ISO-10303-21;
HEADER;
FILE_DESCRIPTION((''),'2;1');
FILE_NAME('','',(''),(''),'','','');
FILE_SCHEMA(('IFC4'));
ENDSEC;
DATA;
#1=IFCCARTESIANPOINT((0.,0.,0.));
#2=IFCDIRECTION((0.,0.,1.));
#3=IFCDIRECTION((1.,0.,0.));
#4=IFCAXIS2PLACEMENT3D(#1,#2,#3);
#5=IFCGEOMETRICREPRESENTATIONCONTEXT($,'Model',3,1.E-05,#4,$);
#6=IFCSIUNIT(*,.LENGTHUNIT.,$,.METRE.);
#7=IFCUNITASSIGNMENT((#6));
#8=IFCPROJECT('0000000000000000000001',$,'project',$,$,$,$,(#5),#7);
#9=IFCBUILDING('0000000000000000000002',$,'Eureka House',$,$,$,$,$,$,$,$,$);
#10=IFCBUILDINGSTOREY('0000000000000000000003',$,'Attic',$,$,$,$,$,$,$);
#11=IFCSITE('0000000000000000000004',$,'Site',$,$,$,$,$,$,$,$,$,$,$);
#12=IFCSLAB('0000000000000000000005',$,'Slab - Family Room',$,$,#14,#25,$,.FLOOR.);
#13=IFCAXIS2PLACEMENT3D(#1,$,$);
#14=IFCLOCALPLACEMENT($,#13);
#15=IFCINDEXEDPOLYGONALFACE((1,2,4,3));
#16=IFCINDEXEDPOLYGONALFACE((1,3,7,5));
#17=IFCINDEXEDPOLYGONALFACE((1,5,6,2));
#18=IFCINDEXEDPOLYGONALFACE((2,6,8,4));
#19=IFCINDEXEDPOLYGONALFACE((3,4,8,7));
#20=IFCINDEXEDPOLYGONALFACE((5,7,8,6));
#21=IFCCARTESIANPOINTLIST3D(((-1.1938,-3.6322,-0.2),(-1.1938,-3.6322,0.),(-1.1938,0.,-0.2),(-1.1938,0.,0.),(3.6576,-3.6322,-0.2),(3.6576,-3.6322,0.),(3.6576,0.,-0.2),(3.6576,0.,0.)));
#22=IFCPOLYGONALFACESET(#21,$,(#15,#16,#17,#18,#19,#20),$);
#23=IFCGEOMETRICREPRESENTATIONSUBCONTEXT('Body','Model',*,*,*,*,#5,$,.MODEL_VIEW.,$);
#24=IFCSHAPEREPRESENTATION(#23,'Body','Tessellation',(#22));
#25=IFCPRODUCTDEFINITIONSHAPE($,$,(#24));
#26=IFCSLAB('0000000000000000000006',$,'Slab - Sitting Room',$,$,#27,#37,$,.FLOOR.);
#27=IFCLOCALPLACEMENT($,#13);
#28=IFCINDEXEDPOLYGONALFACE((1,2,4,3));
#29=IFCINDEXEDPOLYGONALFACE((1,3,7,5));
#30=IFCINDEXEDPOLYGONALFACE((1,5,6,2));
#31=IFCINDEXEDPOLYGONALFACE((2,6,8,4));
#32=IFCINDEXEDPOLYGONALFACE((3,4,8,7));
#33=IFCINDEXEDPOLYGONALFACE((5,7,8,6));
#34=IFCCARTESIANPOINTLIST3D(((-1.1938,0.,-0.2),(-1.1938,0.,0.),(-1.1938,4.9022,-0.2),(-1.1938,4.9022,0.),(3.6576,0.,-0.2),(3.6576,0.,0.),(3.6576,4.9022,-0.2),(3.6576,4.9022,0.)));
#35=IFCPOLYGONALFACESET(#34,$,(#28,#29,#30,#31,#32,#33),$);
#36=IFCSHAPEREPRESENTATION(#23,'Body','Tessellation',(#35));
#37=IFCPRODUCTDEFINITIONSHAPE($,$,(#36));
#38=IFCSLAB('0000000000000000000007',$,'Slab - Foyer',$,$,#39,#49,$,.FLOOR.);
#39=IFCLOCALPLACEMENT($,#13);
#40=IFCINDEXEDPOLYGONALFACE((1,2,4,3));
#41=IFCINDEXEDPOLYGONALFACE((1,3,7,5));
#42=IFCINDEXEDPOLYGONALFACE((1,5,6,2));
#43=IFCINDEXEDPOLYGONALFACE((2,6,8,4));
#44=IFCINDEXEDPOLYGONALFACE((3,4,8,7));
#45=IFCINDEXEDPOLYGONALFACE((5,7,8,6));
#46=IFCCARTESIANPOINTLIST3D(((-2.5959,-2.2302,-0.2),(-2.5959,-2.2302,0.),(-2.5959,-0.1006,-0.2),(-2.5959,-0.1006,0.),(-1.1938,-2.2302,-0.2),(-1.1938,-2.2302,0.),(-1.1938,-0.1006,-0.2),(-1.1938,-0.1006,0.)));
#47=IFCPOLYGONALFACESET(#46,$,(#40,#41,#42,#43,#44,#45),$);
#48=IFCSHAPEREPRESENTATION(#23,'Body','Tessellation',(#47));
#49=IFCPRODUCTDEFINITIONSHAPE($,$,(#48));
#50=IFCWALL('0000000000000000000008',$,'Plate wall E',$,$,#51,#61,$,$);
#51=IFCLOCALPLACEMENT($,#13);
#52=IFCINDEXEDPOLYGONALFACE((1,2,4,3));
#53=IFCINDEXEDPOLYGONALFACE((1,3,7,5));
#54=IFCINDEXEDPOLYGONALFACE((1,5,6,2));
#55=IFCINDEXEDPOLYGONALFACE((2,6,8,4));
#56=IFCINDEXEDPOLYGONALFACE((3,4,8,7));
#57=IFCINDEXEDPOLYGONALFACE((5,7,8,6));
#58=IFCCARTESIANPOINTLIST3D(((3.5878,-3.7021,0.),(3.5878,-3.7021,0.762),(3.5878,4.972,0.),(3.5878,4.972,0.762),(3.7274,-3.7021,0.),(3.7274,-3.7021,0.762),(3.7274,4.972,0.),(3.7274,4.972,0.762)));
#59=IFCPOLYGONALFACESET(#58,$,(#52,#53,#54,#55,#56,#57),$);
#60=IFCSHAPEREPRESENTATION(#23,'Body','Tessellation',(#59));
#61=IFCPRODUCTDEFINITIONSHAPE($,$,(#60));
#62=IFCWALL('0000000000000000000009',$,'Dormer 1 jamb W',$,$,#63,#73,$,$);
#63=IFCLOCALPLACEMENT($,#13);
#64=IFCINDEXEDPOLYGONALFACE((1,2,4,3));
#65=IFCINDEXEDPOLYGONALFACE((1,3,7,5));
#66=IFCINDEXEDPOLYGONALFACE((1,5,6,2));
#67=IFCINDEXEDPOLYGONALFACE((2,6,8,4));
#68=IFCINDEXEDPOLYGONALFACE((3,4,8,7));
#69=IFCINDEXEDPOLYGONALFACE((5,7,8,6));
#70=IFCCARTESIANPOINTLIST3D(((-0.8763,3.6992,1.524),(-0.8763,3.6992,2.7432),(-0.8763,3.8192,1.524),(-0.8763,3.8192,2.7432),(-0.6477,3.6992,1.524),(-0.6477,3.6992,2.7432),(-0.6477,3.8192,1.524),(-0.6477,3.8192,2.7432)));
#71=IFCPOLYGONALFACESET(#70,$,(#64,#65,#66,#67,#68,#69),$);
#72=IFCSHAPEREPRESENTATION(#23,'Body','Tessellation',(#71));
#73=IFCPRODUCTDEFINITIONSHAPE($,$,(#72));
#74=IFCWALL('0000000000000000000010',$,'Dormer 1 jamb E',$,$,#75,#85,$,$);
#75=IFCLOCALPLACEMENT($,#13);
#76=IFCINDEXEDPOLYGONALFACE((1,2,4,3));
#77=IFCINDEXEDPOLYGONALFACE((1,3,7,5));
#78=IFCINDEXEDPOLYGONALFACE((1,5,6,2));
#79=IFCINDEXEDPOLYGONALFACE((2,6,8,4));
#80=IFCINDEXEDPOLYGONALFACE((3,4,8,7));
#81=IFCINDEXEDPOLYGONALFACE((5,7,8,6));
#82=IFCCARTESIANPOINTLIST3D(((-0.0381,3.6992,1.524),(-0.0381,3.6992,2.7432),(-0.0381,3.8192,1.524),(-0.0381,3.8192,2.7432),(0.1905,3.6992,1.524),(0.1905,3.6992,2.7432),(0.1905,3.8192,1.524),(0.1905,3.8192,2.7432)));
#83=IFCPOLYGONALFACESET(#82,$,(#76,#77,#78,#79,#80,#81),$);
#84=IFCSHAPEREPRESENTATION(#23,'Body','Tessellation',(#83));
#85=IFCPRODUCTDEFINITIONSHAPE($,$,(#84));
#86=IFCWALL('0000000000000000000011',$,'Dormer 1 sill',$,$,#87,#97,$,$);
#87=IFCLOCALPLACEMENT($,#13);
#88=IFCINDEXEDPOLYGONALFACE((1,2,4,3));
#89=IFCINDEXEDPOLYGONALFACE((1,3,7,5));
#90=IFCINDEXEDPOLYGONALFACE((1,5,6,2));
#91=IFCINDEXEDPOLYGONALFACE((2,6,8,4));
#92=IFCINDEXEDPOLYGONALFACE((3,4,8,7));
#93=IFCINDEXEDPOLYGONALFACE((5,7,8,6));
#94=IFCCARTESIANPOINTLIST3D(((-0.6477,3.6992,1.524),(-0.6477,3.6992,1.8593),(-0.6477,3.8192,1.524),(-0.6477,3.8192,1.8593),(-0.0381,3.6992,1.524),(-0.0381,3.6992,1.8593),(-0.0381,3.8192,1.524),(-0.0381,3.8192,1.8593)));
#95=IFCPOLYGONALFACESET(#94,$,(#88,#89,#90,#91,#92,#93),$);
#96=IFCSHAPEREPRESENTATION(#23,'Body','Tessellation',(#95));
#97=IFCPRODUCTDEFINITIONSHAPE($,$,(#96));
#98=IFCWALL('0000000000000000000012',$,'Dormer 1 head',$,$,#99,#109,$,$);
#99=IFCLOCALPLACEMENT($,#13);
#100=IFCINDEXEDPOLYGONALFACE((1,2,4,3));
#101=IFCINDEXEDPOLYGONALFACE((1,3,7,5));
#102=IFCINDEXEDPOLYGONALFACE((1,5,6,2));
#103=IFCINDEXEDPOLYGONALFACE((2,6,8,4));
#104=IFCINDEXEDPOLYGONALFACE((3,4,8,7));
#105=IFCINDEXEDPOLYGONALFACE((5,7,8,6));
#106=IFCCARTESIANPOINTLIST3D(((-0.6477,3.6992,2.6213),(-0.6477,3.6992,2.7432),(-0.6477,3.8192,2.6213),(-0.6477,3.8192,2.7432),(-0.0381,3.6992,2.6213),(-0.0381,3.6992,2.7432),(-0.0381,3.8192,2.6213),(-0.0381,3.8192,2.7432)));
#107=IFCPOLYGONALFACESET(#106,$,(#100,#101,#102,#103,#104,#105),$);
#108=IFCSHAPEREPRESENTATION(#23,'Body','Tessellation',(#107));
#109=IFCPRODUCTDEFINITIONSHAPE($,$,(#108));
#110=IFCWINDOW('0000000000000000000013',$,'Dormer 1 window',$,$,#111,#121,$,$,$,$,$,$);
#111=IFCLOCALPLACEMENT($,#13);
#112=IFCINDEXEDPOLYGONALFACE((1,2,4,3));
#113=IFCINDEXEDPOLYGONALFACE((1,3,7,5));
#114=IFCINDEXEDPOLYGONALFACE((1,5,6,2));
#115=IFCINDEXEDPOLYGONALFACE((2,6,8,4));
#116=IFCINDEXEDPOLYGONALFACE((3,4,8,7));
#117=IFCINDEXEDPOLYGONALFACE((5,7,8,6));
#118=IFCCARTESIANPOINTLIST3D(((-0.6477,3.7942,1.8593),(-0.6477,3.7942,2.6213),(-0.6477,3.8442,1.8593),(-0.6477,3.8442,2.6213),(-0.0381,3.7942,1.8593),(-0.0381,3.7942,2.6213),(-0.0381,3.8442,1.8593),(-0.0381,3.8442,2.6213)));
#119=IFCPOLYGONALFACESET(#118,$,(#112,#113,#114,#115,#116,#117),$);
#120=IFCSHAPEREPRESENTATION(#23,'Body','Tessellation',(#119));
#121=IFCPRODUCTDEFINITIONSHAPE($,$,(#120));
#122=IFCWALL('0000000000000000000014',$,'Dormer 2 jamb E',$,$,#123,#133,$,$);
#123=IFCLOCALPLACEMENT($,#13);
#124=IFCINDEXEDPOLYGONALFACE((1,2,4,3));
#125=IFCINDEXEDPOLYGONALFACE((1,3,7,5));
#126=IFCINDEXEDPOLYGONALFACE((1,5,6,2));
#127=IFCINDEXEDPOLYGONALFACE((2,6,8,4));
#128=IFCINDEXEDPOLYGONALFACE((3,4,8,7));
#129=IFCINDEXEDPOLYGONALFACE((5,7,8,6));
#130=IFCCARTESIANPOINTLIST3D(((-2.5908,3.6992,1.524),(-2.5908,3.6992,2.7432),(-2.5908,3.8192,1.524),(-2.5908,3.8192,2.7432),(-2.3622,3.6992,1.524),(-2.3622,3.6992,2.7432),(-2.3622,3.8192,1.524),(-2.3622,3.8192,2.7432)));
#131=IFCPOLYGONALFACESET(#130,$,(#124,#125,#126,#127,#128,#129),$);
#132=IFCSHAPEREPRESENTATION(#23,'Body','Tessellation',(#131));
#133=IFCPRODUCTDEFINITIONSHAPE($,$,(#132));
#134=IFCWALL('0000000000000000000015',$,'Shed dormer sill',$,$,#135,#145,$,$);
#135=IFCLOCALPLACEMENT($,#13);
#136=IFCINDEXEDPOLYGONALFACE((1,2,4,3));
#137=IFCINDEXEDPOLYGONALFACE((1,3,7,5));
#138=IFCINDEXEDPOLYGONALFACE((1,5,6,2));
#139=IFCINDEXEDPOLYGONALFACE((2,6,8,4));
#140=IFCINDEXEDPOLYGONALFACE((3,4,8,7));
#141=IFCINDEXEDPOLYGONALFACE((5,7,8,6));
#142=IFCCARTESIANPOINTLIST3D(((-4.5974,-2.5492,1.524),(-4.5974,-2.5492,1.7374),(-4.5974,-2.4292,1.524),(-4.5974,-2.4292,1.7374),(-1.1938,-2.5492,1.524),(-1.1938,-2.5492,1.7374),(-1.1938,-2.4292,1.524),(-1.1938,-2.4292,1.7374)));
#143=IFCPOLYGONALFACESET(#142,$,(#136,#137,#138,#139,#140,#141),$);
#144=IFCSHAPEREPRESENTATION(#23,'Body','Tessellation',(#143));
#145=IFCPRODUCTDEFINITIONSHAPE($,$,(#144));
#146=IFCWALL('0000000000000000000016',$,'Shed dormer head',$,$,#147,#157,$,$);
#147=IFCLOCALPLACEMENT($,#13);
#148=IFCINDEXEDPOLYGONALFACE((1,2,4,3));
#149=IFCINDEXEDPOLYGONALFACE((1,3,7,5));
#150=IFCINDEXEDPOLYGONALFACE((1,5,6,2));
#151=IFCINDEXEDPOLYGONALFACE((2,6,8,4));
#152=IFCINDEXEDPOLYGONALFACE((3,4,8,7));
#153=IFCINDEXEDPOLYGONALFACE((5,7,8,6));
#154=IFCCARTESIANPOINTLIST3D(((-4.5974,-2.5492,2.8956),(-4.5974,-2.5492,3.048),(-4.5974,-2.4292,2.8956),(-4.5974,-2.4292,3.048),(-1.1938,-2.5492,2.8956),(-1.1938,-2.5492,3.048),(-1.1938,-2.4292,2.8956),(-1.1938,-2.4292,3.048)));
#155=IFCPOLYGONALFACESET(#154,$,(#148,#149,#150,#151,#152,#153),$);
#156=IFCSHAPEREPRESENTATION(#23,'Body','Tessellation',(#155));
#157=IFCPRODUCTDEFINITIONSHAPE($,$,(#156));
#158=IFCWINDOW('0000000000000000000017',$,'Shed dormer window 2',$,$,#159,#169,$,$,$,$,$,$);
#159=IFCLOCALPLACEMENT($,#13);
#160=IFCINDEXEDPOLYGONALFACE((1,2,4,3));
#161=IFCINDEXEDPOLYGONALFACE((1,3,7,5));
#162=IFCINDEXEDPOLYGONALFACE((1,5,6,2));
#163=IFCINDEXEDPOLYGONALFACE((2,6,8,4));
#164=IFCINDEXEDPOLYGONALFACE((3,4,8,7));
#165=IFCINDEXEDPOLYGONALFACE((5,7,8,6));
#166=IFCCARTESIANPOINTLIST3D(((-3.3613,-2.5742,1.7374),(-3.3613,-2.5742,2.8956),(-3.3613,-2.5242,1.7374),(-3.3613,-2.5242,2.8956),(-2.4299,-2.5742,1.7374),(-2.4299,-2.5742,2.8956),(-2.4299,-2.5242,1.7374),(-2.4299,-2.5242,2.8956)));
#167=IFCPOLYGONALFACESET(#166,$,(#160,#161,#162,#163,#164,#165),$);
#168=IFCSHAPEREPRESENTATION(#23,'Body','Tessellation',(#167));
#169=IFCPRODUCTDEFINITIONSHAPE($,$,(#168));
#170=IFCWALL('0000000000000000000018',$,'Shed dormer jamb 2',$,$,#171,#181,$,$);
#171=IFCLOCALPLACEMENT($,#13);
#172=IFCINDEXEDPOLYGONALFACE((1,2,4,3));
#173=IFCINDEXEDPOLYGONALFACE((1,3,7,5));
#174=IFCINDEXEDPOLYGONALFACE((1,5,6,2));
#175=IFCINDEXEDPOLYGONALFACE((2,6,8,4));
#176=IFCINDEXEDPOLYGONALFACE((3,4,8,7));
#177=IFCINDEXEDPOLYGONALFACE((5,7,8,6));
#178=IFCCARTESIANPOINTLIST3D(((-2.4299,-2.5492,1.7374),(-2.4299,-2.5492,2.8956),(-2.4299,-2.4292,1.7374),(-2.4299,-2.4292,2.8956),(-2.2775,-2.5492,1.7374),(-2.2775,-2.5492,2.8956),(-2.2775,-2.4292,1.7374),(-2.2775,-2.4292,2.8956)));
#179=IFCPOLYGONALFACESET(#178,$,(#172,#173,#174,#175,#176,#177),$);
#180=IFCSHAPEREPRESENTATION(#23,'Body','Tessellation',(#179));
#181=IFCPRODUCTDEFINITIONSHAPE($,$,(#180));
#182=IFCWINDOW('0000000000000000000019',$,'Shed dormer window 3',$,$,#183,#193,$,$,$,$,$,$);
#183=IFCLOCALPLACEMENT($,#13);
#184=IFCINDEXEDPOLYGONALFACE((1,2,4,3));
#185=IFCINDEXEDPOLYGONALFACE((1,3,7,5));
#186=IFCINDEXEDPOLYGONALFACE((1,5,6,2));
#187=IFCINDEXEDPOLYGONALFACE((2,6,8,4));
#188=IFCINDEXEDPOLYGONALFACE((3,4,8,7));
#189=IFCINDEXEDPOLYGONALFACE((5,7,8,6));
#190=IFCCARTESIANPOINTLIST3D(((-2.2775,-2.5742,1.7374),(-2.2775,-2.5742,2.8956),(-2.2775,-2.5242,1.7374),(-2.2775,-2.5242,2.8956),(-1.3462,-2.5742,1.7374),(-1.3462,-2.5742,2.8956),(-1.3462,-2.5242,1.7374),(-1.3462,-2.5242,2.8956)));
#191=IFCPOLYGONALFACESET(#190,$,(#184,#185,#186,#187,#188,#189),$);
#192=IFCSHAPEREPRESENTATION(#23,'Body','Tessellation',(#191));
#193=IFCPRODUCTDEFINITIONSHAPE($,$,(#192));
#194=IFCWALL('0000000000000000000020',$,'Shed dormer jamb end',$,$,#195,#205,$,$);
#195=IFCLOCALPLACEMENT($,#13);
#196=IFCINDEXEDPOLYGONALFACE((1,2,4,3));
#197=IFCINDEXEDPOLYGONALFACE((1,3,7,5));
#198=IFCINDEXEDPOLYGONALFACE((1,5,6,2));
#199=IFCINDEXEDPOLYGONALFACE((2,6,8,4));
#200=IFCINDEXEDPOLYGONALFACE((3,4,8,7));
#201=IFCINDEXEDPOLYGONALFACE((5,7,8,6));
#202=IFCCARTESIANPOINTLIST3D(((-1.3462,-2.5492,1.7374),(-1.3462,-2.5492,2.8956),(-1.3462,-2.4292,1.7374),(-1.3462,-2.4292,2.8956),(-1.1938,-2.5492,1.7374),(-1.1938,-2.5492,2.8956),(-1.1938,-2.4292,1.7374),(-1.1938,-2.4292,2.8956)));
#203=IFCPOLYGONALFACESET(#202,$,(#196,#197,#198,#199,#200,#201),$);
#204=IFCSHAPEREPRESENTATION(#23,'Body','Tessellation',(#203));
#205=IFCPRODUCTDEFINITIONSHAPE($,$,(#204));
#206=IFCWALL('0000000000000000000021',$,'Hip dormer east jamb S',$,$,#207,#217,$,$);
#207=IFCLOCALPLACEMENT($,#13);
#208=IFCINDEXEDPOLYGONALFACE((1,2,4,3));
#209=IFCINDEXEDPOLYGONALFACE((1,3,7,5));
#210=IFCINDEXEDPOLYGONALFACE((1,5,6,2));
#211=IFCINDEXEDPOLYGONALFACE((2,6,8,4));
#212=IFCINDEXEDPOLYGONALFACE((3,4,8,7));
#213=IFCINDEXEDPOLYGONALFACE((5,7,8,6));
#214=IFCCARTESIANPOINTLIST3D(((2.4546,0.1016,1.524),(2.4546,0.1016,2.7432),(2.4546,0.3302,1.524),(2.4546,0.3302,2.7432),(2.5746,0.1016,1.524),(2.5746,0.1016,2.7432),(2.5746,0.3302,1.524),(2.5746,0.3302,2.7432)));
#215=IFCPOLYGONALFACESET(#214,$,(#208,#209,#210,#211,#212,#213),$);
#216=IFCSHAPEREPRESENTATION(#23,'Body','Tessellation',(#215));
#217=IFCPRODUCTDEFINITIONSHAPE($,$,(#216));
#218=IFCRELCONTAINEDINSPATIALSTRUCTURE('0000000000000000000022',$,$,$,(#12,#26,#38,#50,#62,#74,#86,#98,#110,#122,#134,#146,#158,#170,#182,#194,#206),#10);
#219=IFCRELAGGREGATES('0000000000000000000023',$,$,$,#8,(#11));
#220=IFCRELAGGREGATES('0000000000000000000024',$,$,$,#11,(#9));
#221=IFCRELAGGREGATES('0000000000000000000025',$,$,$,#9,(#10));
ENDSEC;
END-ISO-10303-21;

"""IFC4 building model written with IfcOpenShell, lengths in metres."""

from ifc_helpers import new_model, si_unit, frame, origin, origin_with_axes, origin_2d, place, context, subcontext, project, spatial, rectangle, extrude, element, save


model = new_model("IFC4")

# Units and contexts
model_context = context("Model", 3, precision=1e-05, world=origin_with_axes())
body_context = subcontext(model_context, "Body", "Model", "MODEL_VIEW")
ifc_project = project(units=[si_unit("LENGTHUNIT", "METRE")], contexts=[model_context])

# Site, building, storey
site = spatial("IfcSite", under=ifc_project, Name="Site")
building = spatial("IfcBuilding", under=site, Name="Eureka House")
storey = spatial("IfcBuildingStorey", under=building, Name="Attic")

# Slabs
slab_1_placement = place(None, frame((1.2319, -1.8161, -0.2), z_axis=(0.0, 0.0, 1.0), x_axis=(1.0, 0.0, 0.0)))
element("IfcSlab", 1, at=slab_1_placement, inside=storey, Name="Slab - Family Room", PredefinedType="FLOOR", context=body_context, shape_type="SweptSolid", body=[
    extrude(rectangle(XDim=4.8514, YDim=3.6322, at=origin_2d()), origin(), (0.0, 0.0, 1.0), 0.2),
])
slab_2_placement = place(None, frame((1.2319, 2.4511, -0.2), z_axis=(0.0, 0.0, 1.0), x_axis=(1.0, 0.0, 0.0)))
element("IfcSlab", 2, at=slab_2_placement, inside=storey, Name="Slab - Sitting Room", PredefinedType="FLOOR", context=body_context, shape_type="SweptSolid", body=[
    extrude(rectangle(XDim=4.8514, YDim=4.9022, at=origin_2d()), origin(), (0.0, 0.0, 1.0), 0.2),
])
slab_3_placement = place(None, frame((-1.8949, -1.1654, -0.2), z_axis=(0.0, 0.0, 1.0), x_axis=(1.0, 0.0, 0.0)))
element("IfcSlab", 3, at=slab_3_placement, inside=storey, Name="Slab - Foyer", PredefinedType="FLOOR", context=body_context, shape_type="SweptSolid", body=[
    extrude(rectangle(XDim=1.4021, YDim=2.1296, at=origin_2d()), origin(), (0.0, 0.0, 1.0), 0.2),
])

# Walls
wall_1_placement = place(None, frame((3.6576, 0.635, 0.0), z_axis=(0.0, 0.0, 1.0), x_axis=(1.0, 0.0, 0.0)))
element("IfcWall", 4, at=wall_1_placement, inside=storey, Name="Plate wall E", context=body_context, shape_type="SweptSolid", body=[
    extrude(rectangle(XDim=0.1397, YDim=8.6741, at=origin_2d()), origin(), (0.0, 0.0, 1.0), 0.762),
])
wall_2_placement = place(None, frame((-0.762, 3.7592, 1.524), z_axis=(0.0, 0.0, 1.0), x_axis=(1.0, 0.0, 0.0)))
element("IfcWall", 5, at=wall_2_placement, inside=storey, Name="Dormer 1 jamb W", context=body_context, shape_type="SweptSolid", body=[
    extrude(rectangle(XDim=0.2286, YDim=0.12, at=origin_2d()), origin(), (0.0, 0.0, 1.0), 1.2192),
])
wall_3_placement = place(None, frame((0.0762, 3.7592, 1.524), z_axis=(0.0, 0.0, 1.0), x_axis=(1.0, 0.0, 0.0)))
element("IfcWall", 6, at=wall_3_placement, inside=storey, Name="Dormer 1 jamb E", context=body_context, shape_type="SweptSolid", body=[
    extrude(rectangle(XDim=0.2286, YDim=0.12, at=origin_2d()), origin(), (0.0, 0.0, 1.0), 1.2192),
])
wall_4_placement = place(None, frame((-0.3429, 3.7592, 1.524), z_axis=(0.0, 0.0, 1.0), x_axis=(1.0, 0.0, 0.0)))
element("IfcWall", 7, at=wall_4_placement, inside=storey, Name="Dormer 1 sill", context=body_context, shape_type="SweptSolid", body=[
    extrude(rectangle(XDim=0.6096, YDim=0.12, at=origin_2d()), origin(), (0.0, 0.0, 1.0), 0.3353),
])
wall_5_placement = place(None, frame((-0.3429, 3.7592, 2.6213), z_axis=(0.0, 0.0, 1.0), x_axis=(1.0, 0.0, 0.0)))
element("IfcWall", 8, at=wall_5_placement, inside=storey, Name="Dormer 1 head", context=body_context, shape_type="SweptSolid", body=[
    extrude(rectangle(XDim=0.6096, YDim=0.12, at=origin_2d()), origin(), (0.0, 0.0, 1.0), 0.1219),
])

# Window
window_1_placement = place(None, frame((-0.3429, 3.8192, 1.8593), z_axis=(0.0, 0.0, 1.0), x_axis=(1.0, 0.0, 0.0)))
element("IfcWindow", 9, at=window_1_placement, inside=storey, Name="Dormer 1 window", context=body_context, shape_type="SweptSolid", body=[
    extrude(rectangle(XDim=0.6096, YDim=0.05, at=origin_2d()), origin(), (0.0, 0.0, 1.0), 0.762),
])

# Walls
wall_6_placement = place(None, frame((-2.4765, 3.7592, 1.524), z_axis=(0.0, 0.0, 1.0), x_axis=(1.0, 0.0, 0.0)))
element("IfcWall", 10, at=wall_6_placement, inside=storey, Name="Dormer 2 jamb E", context=body_context, shape_type="SweptSolid", body=[
    extrude(rectangle(XDim=0.2286, YDim=0.12, at=origin_2d()), origin(), (0.0, 0.0, 1.0), 1.2192),
])
wall_7_placement = place(None, frame((-2.8956, -2.4892, 1.524), z_axis=(0.0, 0.0, 1.0), x_axis=(1.0, 0.0, 0.0)))
element("IfcWall", 11, at=wall_7_placement, inside=storey, Name="Shed dormer sill", context=body_context, shape_type="SweptSolid", body=[
    extrude(rectangle(XDim=3.4036, YDim=0.12, at=origin_2d()), origin(), (0.0, 0.0, 1.0), 0.2134),
])
wall_8_placement = place(None, frame((-2.8956, -2.4892, 2.8956), z_axis=(0.0, 0.0, 1.0), x_axis=(1.0, 0.0, 0.0)))
element("IfcWall", 12, at=wall_8_placement, inside=storey, Name="Shed dormer head", context=body_context, shape_type="SweptSolid", body=[
    extrude(rectangle(XDim=3.4036, YDim=0.12, at=origin_2d()), origin(), (0.0, 0.0, 1.0), 0.1524),
])

# Window
window_2_placement = place(None, frame((-2.8956, -2.5492, 1.7374), z_axis=(0.0, 0.0, 1.0), x_axis=(1.0, 0.0, 0.0)))
element("IfcWindow", 13, at=window_2_placement, inside=storey, Name="Shed dormer window 2", context=body_context, shape_type="SweptSolid", body=[
    extrude(rectangle(XDim=0.9313, YDim=0.05, at=origin_2d()), origin(), (0.0, 0.0, 1.0), 1.1582),
])

# Wall
wall_9_placement = place(None, frame((-2.3537, -2.4892, 1.7374), z_axis=(0.0, 0.0, 1.0), x_axis=(1.0, 0.0, 0.0)))
element("IfcWall", 14, at=wall_9_placement, inside=storey, Name="Shed dormer jamb 2", context=body_context, shape_type="SweptSolid", body=[
    extrude(rectangle(XDim=0.1524, YDim=0.12, at=origin_2d()), origin(), (0.0, 0.0, 1.0), 1.1582),
])

# Window
window_3_placement = place(None, frame((-1.8119, -2.5492, 1.7374), z_axis=(0.0, 0.0, 1.0), x_axis=(1.0, 0.0, 0.0)))
element("IfcWindow", 15, at=window_3_placement, inside=storey, Name="Shed dormer window 3", context=body_context, shape_type="SweptSolid", body=[
    extrude(rectangle(XDim=0.9313, YDim=0.05, at=origin_2d()), origin(), (0.0, 0.0, 1.0), 1.1582),
])

# Walls
wall_10_placement = place(None, frame((-1.27, -2.4892, 1.7374), z_axis=(0.0, 0.0, 1.0), x_axis=(1.0, 0.0, 0.0)))
element("IfcWall", 16, at=wall_10_placement, inside=storey, Name="Shed dormer jamb end", context=body_context, shape_type="SweptSolid", body=[
    extrude(rectangle(XDim=0.1524, YDim=0.12, at=origin_2d()), origin(), (0.0, 0.0, 1.0), 1.1582),
])
wall_11_placement = place(None, frame((2.5146, 0.2159, 1.524), z_axis=(0.0, 0.0, 1.0), x_axis=(1.0, 0.0, 0.0)))
element("IfcWall", 17, at=wall_11_placement, inside=storey, Name="Hip dormer east jamb S", context=body_context, shape_type="SweptSolid", body=[
    extrude(rectangle(XDim=0.12, YDim=0.2286, at=origin_2d()), origin(), (0.0, 0.0, 1.0), 1.2192),
])

save(model, "model.ifc")
